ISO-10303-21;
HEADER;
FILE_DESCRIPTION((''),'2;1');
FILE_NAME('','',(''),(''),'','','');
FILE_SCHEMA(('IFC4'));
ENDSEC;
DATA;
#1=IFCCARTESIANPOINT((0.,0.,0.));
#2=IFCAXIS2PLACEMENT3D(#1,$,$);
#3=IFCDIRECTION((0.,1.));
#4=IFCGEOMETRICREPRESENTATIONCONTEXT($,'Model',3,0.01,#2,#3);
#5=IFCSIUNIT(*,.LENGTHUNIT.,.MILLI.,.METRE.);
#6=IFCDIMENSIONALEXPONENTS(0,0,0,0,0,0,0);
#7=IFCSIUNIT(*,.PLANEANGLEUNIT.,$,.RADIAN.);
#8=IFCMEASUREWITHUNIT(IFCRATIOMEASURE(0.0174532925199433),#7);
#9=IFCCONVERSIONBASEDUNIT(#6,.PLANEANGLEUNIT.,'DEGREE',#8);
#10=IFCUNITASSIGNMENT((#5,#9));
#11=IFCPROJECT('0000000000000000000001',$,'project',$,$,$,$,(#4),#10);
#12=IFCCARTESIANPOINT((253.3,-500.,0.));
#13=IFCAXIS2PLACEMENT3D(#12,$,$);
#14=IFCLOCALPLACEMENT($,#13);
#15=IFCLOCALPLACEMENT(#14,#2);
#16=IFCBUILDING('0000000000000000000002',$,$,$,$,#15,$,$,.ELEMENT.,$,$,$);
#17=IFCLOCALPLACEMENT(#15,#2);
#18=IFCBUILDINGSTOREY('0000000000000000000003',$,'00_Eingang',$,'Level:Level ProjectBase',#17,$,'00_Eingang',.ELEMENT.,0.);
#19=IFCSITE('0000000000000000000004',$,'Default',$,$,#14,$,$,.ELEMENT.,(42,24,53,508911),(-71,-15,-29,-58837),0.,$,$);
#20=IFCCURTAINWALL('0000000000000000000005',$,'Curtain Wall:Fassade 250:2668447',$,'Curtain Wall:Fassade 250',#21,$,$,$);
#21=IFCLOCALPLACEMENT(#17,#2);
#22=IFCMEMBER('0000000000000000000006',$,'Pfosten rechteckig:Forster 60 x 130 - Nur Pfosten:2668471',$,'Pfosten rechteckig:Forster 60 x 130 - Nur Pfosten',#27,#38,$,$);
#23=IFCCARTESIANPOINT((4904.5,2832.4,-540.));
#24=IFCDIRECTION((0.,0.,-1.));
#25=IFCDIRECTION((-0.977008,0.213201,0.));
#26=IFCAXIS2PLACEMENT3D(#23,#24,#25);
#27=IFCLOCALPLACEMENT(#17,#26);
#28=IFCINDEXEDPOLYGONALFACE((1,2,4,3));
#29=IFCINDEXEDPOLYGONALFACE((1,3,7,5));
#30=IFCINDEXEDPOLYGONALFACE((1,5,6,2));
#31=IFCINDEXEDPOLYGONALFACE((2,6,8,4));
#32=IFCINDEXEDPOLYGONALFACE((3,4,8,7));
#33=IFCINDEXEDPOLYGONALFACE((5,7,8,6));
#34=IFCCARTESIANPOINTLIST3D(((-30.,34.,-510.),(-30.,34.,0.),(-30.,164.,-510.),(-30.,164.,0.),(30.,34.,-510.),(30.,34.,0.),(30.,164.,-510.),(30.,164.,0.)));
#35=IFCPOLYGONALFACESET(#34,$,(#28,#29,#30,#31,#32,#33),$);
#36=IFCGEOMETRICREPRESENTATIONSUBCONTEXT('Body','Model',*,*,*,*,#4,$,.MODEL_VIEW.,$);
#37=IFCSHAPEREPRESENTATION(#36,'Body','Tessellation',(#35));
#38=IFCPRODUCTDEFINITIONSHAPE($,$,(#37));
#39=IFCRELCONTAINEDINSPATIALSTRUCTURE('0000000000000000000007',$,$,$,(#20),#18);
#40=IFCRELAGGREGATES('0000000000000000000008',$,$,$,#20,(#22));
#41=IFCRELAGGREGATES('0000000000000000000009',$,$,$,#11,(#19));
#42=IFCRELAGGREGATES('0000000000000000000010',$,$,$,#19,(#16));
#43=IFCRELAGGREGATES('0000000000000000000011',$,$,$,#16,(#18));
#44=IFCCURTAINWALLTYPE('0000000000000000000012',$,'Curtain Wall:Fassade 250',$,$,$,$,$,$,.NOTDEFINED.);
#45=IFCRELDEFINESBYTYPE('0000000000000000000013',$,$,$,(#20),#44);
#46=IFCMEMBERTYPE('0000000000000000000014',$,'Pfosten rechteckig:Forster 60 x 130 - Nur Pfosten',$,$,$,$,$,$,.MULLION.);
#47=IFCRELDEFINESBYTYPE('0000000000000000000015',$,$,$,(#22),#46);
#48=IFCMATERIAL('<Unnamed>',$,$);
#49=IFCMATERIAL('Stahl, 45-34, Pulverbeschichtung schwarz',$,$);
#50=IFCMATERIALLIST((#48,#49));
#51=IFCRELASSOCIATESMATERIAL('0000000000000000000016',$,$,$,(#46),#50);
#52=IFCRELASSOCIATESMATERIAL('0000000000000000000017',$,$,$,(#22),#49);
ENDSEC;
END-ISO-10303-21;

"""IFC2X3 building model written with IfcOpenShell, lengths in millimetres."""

from ifc_helpers import new_model, entity, si_unit, converted_unit, direction, frame, origin, origin_2d_with_axis, place, context, subcontext, project, spatial, rectangle, extrude, source, transform, mapped, material, material_list, type_object, type_shapes, element, aggregate, save


model = new_model("IFC2X3")

# Units and contexts
model_context = context("Model", 3, precision=0.01, world=origin(), true_north=direction((0.0, 1.0)))
body_context = subcontext(model_context, "Body", "Model", "MODEL_VIEW")
ifc_project = project(units=[si_unit("LENGTHUNIT", "METRE", prefix="MILLI"), converted_unit("PLANEANGLEUNIT", "DEGREE", entity("IfcRatioMeasure", 0.0174532925199433), si_unit("PLANEANGLEUNIT", "RADIAN"), dimensions=[0, 0, 0, 0, 0, 0, 0])], contexts=[model_context])

# Site, building, storey
site_placement = place(None, frame((253.3, -500.0, 0.0)))
site = spatial("IfcSite", under=ifc_project, at=site_placement, Name="Default", CompositionType="ELEMENT", RefLatitude=(42, 24, 53, 508911), RefLongitude=(-71, -15, -29, -58837), RefElevation=0.0)
building_placement = place(site_placement, origin())
building = spatial("IfcBuilding", under=site, at=building_placement, CompositionType="ELEMENT")
storey_placement = place(building_placement, origin())
storey = spatial("IfcBuildingStorey", under=building, at=storey_placement, Name="00_Eingang", ObjectType="Level:Level ProjectBase", LongName="00_Eingang", CompositionType="ELEMENT", Elevation=0.0)

# Curtain wall, member
curtain_wall_type = type_object("IfcCurtainWallType", Name="Curtain Wall:Fassade 250", PredefinedType="NOTDEFINED")
curtain_wall_placement = place(storey_placement, origin())
curtain_wall = element("IfcCurtainWall", 1, at=curtain_wall_placement, inside=storey, type_object=curtain_wall_type, Name="Curtain Wall:Fassade 250:2668447", ObjectType="Curtain Wall:Fassade 250")
ifc_material_1 = material(Name="Stahl, 45-34, Pulverbeschichtung schwarz")
ifc_material_2 = material(Name="<Unnamed>")
ifc_material_list_1 = material_list([ifc_material_2, ifc_material_1])
member_type_1 = type_object("IfcMemberType", Name="Pfosten rechteckig:Forster 60 x 130 - Nur Pfosten", PredefinedType="MULLION", material=ifc_material_list_1)
shared_shape_1 = source(origin(), body_context, "Body", "SweptSolid", [
    extrude(rectangle(XDim=130.0, YDim=60.0, at=origin_2d_with_axis()), frame((0.0, 99.0, -510.0), z_axis=(0.0, 0.0, 1.0), x_axis=(0.0, -1.0, 0.0)), (0.0, 0.0, 1.0), 510.0),
])
type_shapes(member_type_1, [shared_shape_1])
member_1_placement = place(storey_placement, frame((4904.5, 2832.4, -540.0), z_axis=(0.0, 0.0, -1.0), x_axis=(-0.977008, 0.213201, 0.0)))
member_1 = element("IfcMember", 2, at=member_1_placement, type_object=member_type_1, material=ifc_material_1, Name="Pfosten rechteckig:Forster 60 x 130 - Nur Pfosten:2668471", ObjectType="Pfosten rechteckig:Forster 60 x 130 - Nur Pfosten", context=body_context, shape_type="MappedRepresentation", body=[
    mapped(shared_shape_1, transform((0.0, 0.0, 0.0), scale=1.0)),
])

aggregate(curtain_wall, [member_1])

save(model, "model.ifc")
